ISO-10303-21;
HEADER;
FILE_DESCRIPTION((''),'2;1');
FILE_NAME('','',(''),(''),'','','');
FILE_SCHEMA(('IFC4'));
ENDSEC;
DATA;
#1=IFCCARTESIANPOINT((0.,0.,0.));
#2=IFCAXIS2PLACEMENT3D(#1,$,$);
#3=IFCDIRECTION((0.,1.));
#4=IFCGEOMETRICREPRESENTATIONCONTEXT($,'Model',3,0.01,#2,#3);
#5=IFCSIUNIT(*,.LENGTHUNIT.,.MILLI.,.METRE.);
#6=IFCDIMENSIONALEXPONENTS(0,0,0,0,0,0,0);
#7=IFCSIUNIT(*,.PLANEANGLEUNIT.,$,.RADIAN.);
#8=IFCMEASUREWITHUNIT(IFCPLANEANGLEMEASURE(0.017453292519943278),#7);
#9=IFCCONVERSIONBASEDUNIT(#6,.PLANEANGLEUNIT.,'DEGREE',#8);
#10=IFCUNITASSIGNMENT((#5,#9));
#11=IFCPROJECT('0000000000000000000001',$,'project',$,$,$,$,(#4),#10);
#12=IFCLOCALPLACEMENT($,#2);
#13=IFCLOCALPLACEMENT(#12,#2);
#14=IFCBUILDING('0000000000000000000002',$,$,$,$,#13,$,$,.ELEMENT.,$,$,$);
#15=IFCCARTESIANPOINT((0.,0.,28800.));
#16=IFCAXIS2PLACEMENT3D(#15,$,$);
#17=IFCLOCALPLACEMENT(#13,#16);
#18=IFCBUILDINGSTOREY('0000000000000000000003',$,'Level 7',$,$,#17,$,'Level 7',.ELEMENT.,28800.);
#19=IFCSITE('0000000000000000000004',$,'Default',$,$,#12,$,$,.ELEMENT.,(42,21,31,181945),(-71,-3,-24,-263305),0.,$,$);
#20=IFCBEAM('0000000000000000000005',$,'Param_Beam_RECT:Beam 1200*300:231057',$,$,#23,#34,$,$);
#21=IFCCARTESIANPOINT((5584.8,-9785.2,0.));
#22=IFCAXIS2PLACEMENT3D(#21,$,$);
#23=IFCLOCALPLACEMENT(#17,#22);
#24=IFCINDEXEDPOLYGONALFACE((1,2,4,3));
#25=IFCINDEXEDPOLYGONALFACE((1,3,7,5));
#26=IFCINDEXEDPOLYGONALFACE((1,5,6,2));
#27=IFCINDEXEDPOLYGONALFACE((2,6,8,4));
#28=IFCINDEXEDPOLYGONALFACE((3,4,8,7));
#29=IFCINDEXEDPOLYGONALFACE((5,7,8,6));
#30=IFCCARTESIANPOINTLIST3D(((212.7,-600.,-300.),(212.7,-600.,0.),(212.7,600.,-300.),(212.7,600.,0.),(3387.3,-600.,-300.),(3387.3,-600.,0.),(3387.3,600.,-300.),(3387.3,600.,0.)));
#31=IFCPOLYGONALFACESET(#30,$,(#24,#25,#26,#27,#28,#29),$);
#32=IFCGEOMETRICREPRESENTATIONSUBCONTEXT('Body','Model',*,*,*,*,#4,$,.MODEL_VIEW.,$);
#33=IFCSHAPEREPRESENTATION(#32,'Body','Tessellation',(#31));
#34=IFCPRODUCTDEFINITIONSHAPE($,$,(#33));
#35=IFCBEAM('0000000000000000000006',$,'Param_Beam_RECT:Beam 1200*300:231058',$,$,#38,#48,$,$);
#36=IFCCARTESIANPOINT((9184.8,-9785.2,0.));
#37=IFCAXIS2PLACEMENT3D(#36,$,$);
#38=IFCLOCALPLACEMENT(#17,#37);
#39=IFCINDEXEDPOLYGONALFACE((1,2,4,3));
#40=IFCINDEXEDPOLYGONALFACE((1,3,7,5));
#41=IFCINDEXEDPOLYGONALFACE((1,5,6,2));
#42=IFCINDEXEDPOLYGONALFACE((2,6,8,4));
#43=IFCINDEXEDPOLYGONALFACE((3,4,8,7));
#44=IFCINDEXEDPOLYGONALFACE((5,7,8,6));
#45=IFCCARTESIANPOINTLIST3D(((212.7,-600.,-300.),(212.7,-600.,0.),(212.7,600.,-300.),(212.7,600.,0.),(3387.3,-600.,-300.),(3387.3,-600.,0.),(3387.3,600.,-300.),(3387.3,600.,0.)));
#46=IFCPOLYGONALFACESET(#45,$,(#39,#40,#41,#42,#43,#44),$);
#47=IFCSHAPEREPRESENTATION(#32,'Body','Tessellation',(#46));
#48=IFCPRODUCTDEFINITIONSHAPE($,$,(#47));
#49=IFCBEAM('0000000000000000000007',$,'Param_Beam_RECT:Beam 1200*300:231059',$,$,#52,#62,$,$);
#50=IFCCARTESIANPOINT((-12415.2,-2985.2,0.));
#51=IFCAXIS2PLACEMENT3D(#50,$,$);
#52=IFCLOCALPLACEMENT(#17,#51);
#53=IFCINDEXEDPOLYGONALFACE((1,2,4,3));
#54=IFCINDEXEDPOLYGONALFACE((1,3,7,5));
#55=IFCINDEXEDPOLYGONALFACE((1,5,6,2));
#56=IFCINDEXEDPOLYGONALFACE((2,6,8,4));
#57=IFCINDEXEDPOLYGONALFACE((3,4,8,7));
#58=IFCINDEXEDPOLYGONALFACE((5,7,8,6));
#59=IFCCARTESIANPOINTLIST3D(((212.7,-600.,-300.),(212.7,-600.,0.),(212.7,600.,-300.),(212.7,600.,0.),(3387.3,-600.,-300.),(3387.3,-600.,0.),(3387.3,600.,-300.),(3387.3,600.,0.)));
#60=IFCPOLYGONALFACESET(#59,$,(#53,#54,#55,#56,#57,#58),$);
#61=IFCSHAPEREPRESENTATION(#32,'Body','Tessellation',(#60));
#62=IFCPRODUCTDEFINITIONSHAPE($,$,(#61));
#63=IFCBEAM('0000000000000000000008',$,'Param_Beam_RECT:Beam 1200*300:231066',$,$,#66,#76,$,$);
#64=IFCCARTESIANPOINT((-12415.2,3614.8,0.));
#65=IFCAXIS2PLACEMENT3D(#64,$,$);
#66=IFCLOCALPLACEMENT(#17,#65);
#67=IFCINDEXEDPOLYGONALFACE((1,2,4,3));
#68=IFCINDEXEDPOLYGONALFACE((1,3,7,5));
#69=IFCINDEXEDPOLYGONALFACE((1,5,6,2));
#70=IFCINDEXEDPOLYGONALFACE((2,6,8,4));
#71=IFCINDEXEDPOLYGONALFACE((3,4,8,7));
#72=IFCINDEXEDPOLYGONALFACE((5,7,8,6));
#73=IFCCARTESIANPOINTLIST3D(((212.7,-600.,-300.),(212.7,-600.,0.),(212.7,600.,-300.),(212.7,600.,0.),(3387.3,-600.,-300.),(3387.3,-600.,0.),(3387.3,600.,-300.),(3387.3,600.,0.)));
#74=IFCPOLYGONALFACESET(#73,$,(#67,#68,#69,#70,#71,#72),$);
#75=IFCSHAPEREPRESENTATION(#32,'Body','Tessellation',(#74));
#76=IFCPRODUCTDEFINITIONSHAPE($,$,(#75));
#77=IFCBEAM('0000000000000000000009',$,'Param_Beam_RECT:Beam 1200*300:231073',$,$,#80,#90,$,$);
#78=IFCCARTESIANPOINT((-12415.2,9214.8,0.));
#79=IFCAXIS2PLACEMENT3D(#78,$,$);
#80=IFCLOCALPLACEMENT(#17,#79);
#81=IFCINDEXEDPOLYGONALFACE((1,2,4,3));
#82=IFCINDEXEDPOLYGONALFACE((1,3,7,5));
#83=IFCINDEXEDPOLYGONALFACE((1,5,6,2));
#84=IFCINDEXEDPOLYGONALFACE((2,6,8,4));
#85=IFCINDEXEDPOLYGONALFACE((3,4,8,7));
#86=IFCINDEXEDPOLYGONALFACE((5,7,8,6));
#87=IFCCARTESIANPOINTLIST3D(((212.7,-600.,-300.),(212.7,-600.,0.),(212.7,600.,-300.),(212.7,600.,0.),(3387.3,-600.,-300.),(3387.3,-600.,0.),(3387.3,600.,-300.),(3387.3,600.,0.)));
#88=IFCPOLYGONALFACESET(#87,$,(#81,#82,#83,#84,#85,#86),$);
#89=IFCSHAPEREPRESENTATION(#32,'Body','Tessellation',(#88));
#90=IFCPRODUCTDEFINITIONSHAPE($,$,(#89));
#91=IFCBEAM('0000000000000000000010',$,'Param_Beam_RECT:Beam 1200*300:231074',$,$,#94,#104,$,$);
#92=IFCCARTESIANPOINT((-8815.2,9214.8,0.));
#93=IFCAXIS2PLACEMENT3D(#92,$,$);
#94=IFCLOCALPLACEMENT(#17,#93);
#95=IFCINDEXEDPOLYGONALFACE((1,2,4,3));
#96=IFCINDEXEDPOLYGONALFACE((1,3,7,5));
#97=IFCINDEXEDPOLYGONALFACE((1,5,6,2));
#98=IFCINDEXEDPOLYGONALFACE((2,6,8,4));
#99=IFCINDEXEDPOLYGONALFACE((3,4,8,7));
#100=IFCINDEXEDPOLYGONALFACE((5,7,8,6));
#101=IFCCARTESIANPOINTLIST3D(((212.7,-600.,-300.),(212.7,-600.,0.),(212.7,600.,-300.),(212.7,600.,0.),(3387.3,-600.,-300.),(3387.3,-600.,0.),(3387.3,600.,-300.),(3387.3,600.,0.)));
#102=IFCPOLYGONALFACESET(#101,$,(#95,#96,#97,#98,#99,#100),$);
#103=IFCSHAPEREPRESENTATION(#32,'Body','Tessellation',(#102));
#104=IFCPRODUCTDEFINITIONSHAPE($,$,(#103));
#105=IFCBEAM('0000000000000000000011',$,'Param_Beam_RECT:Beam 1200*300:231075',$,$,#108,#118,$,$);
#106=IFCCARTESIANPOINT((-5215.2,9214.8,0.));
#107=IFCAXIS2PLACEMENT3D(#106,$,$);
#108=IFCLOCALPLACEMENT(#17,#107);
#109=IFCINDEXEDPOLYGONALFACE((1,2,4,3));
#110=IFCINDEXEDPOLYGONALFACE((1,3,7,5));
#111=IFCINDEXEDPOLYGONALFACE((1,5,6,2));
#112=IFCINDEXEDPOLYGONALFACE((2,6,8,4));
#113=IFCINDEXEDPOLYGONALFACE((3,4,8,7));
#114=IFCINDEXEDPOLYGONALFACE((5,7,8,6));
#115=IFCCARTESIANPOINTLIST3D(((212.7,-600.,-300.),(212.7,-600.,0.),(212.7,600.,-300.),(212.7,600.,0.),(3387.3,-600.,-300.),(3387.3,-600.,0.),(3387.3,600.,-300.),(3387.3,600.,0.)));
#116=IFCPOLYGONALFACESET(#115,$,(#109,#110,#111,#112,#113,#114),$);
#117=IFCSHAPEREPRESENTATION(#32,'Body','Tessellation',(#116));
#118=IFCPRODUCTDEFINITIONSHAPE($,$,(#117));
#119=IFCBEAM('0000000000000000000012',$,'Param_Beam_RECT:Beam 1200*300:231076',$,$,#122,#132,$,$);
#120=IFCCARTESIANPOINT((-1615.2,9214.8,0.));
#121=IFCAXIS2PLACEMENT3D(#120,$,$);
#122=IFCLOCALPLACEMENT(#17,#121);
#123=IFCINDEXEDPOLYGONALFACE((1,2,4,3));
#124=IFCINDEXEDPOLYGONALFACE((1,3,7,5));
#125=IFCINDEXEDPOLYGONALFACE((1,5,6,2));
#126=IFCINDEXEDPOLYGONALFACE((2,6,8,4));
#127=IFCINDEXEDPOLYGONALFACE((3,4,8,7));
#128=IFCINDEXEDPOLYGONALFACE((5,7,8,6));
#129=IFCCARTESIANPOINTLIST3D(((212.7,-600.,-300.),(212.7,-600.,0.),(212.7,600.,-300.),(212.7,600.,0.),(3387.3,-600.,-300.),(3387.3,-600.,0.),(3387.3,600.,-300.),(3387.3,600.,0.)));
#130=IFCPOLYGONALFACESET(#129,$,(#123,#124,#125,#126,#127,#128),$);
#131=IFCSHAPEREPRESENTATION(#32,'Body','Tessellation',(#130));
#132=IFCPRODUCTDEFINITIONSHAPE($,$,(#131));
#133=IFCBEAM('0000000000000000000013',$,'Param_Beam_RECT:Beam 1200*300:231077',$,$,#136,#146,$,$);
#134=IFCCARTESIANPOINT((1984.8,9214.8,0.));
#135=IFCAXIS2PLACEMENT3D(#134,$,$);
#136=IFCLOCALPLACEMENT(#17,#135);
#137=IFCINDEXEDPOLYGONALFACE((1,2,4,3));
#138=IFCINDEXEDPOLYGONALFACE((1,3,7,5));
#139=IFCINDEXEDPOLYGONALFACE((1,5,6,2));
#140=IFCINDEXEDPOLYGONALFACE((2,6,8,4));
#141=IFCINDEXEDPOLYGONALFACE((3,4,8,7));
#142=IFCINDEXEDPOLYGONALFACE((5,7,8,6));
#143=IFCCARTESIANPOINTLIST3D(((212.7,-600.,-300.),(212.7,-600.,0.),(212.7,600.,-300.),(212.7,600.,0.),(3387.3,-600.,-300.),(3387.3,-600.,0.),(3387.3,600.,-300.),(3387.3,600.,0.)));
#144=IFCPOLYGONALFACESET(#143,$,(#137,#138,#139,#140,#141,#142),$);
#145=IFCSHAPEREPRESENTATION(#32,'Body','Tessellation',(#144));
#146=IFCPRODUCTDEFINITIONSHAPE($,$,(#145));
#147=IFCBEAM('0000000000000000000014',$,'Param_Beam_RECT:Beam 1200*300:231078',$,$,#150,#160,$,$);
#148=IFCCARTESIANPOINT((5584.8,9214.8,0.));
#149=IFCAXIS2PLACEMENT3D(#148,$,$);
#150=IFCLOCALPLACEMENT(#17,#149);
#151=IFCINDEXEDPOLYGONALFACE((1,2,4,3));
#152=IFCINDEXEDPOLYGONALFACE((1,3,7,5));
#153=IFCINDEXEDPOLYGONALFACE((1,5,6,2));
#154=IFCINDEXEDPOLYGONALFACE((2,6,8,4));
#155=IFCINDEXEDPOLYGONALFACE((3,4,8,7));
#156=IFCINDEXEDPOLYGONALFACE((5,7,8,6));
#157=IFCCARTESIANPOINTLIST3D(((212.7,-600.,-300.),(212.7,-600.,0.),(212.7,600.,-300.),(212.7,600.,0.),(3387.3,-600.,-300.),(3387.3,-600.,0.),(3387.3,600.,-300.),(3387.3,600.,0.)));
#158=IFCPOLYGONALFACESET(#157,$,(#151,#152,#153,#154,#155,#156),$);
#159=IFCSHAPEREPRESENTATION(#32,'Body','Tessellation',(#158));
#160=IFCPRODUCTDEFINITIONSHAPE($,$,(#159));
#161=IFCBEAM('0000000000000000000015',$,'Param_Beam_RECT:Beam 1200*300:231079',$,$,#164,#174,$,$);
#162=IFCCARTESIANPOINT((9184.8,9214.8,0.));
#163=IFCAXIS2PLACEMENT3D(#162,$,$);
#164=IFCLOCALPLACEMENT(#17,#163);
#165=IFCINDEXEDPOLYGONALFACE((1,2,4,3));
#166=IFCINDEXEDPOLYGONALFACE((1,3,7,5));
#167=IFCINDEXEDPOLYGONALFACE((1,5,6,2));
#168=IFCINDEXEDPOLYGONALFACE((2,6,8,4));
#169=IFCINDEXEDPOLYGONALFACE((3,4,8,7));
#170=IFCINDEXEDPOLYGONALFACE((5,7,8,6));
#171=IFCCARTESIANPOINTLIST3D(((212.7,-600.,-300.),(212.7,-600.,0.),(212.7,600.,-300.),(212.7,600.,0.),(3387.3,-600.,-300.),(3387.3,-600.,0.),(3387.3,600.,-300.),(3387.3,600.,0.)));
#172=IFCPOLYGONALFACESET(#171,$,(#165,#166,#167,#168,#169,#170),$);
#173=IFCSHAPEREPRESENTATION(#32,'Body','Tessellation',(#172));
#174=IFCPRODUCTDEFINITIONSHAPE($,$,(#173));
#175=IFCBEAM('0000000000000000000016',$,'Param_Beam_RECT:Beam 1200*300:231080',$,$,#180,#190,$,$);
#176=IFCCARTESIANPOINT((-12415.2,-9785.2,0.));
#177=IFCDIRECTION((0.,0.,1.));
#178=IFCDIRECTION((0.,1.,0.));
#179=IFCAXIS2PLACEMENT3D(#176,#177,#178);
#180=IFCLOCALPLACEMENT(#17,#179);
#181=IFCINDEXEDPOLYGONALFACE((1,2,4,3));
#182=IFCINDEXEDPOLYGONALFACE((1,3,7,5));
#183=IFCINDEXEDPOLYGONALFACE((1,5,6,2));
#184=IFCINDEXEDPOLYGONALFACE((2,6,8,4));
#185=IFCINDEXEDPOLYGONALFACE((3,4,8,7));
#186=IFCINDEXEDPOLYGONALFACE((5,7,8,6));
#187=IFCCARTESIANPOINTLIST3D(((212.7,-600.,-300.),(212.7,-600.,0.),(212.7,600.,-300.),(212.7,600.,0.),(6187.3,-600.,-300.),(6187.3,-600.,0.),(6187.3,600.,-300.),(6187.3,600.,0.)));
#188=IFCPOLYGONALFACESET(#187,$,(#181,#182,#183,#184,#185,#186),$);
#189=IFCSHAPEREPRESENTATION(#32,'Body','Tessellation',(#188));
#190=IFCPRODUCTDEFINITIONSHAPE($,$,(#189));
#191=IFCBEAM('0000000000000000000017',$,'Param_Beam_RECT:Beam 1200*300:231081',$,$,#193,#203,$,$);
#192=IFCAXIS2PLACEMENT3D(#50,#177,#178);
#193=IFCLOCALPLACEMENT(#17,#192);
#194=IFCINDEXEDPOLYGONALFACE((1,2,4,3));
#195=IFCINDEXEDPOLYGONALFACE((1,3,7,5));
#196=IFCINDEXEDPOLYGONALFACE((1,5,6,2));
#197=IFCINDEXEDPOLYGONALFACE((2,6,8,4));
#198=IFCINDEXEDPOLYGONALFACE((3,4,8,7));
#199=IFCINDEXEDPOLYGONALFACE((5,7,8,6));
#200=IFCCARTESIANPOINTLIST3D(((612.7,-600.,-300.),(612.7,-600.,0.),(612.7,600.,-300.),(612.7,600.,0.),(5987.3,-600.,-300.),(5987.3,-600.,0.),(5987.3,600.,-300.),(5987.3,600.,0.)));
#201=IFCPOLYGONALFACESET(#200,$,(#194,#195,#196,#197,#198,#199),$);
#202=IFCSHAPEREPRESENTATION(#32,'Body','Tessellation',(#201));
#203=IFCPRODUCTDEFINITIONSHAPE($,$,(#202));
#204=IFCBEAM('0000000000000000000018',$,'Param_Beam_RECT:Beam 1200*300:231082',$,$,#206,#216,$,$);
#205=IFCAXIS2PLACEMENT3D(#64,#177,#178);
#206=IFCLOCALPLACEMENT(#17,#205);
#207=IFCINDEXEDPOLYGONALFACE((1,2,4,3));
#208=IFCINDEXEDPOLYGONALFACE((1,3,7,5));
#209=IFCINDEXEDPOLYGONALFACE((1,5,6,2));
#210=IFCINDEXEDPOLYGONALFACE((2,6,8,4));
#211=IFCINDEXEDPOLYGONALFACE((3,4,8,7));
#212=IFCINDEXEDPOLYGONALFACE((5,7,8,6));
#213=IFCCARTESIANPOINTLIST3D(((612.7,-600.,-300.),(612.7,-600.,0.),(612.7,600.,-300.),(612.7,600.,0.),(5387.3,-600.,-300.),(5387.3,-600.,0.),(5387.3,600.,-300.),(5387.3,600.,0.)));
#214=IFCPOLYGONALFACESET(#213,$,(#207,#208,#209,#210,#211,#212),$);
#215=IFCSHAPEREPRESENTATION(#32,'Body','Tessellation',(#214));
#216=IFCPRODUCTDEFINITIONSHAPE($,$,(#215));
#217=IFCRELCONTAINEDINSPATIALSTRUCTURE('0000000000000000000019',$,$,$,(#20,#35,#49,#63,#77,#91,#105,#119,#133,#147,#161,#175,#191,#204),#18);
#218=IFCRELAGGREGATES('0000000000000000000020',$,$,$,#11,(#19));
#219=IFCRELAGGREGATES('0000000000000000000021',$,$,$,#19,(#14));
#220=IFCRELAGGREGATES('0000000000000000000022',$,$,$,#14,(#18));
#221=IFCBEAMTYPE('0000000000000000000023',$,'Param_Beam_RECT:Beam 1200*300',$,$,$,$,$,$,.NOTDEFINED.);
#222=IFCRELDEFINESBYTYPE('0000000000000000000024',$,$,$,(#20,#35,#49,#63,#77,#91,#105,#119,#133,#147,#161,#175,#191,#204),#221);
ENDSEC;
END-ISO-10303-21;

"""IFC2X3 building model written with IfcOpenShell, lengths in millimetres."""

from ifc_helpers import new_model, entity, si_unit, converted_unit, direction, frame, frame_2d, origin, origin_2d_with_axis, place, context, subcontext, project, spatial, rectangle, extrude, type_object, element, save


model = new_model("IFC2X3")

# Units and contexts
model_context = context("Model", 3, precision=0.01, world=origin(), true_north=direction((0.0, 1.0)))
body_context = subcontext(model_context, "Body", "Model", "MODEL_VIEW")
ifc_project = project(units=[si_unit("LENGTHUNIT", "METRE", prefix="MILLI"), converted_unit("PLANEANGLEUNIT", "DEGREE", entity("IfcPlaneAngleMeasure", 0.017453292519943278), si_unit("PLANEANGLEUNIT", "RADIAN"), dimensions=[0, 0, 0, 0, 0, 0, 0])], contexts=[model_context])

# Site, building, storey
site_placement = place(None, origin())
site = spatial("IfcSite", under=ifc_project, at=site_placement, Name="Default", CompositionType="ELEMENT", RefLatitude=(42, 21, 31, 181945), RefLongitude=(-71, -3, -24, -263305), RefElevation=0.0)
building_placement = place(site_placement, origin())
building = spatial("IfcBuilding", under=site, at=building_placement, CompositionType="ELEMENT")
storey_placement = place(building_placement, frame((0.0, 0.0, 28800.0)))
storey = spatial("IfcBuildingStorey", under=building, at=storey_placement, Name="Level 7", LongName="Level 7", CompositionType="ELEMENT", Elevation=28800.0)

# Beams
beam_type_1 = type_object("IfcBeamType", Name="Param_Beam_RECT:Beam 1200*300", PredefinedType="NOTDEFINED")
for number, where, name in (
    (1, (5584.8, -9785.2, 0.0), "Param_Beam_RECT:Beam 1200*300:231057"),
    (2, (9184.8, -9785.2, 0.0), "Param_Beam_RECT:Beam 1200*300:231058"),
):
    element("IfcBeam", number, at=place(storey_placement, frame(where)), inside=storey, type_object=beam_type_1, Name=name, context=body_context, shape_type="SweptSolid", body=[
        extrude(rectangle(XDim=300.0, YDim=1200.0, at=frame_2d((0.0, 0.0), x_axis=(1.0, 0.0))), frame((212.7, 0.0, -150.0), z_axis=(1.0, 0.0, 0.0), x_axis=(0.0, 0.0, -1.0)), (0.0, 0.0, 1.0), 3174.6),
    ])
beam_1_placement = place(storey_placement, frame((-12415.2, -2985.2, 0.0)))
element("IfcBeam", 3, at=beam_1_placement, inside=storey, type_object=beam_type_1, Name="Param_Beam_RECT:Beam 1200*300:231059", context=body_context, shape_type="SweptSolid", body=[
    extrude(rectangle(XDim=300.0, YDim=1200.0, at=frame_2d((0.0, 0.0), x_axis=(1.0, 0.0))), frame((212.7, 0.0, -150.0), z_axis=(1.0, 0.0, 0.0), x_axis=(0.0, 0.0, -1.0)), (0.0, 0.0, 1.0), 3174.6),
])
beam_2_placement = place(storey_placement, frame((-12415.2, 3614.8, 0.0)))
element("IfcBeam", 4, at=beam_2_placement, inside=storey, type_object=beam_type_1, Name="Param_Beam_RECT:Beam 1200*300:231066", context=body_context, shape_type="SweptSolid", body=[
    extrude(rectangle(XDim=300.0, YDim=1200.0, at=origin_2d_with_axis()), frame((212.7, 0.0, -150.0), z_axis=(1.0, 0.0, 0.0), x_axis=(0.0, 0.0, -1.0)), (0.0, 0.0, 1.0), 3174.6),
])
beam_3_placement = place(storey_placement, frame((-12415.2, 9214.8, 0.0)))
element("IfcBeam", 5, at=beam_3_placement, inside=storey, type_object=beam_type_1, Name="Param_Beam_RECT:Beam 1200*300:231073", context=body_context, shape_type="SweptSolid", body=[
    extrude(rectangle(XDim=300.0, YDim=1200.0, at=frame_2d((0.0, 0.0), x_axis=(1.0, 0.0))), frame((212.7, 0.0, -150.0), z_axis=(1.0, 0.0, 0.0), x_axis=(0.0, 0.0, -1.0)), (0.0, 0.0, 1.0), 3174.6),
])
for number, where, name in (
    (6, (-8815.2, 9214.8, 0.0), "Param_Beam_RECT:Beam 1200*300:231074"),
    (7, (-5215.2, 9214.8, 0.0), "Param_Beam_RECT:Beam 1200*300:231075"),
):
    element("IfcBeam", number, at=place(storey_placement, frame(where)), inside=storey, type_object=beam_type_1, Name=name, context=body_context, shape_type="SweptSolid", body=[
        extrude(rectangle(XDim=300.0, YDim=1200.0, at=frame_2d((0.0, 0.0), x_axis=(1.0, 0.0))), frame((212.7, 0.0, -150.0), z_axis=(1.0, 0.0, 0.0), x_axis=(0.0, 0.0, -1.0)), (0.0, 0.0, 1.0), 3174.6),
    ])
beam_4_placement = place(storey_placement, frame((-1615.2, 9214.8, 0.0)))
element("IfcBeam", 8, at=beam_4_placement, inside=storey, type_object=beam_type_1, Name="Param_Beam_RECT:Beam 1200*300:231076", context=body_context, shape_type="SweptSolid", body=[
    extrude(rectangle(XDim=300.0, YDim=1200.0, at=frame_2d((0.0, 0.0), x_axis=(1.0, 0.0))), frame((212.7, 0.0, -150.0), z_axis=(1.0, 0.0, 0.0), x_axis=(0.0, 0.0, -1.0)), (0.0, 0.0, 1.0), 3174.6),
])
beam_5_placement = place(storey_placement, frame((1984.8, 9214.8, 0.0)))
element("IfcBeam", 9, at=beam_5_placement, inside=storey, type_object=beam_type_1, Name="Param_Beam_RECT:Beam 1200*300:231077", context=body_context, shape_type="SweptSolid", body=[
    extrude(rectangle(XDim=300.0, YDim=1200.0, at=origin_2d_with_axis()), frame((212.7, 0.0, -150.0), z_axis=(1.0, 0.0, 0.0), x_axis=(0.0, 0.0, -1.0)), (0.0, 0.0, 1.0), 3174.6),
])
for number, where, name in (
    (10, (5584.8, 9214.8, 0.0), "Param_Beam_RECT:Beam 1200*300:231078"),
    (11, (9184.8, 9214.8, 0.0), "Param_Beam_RECT:Beam 1200*300:231079"),
):
    element("IfcBeam", number, at=place(storey_placement, frame(where)), inside=storey, type_object=beam_type_1, Name=name, context=body_context, shape_type="SweptSolid", body=[
        extrude(rectangle(XDim=300.0, YDim=1200.0, at=frame_2d((0.0, 0.0), x_axis=(1.0, 0.0))), frame((212.7, 0.0, -150.0), z_axis=(1.0, 0.0, 0.0), x_axis=(0.0, 0.0, -1.0)), (0.0, 0.0, 1.0), 3174.6),
    ])
beam_6_placement = place(storey_placement, frame((-12415.2, -9785.2, 0.0), z_axis=(0.0, 0.0, 1.0), x_axis=(0.0, 1.0, 0.0)))
element("IfcBeam", 12, at=beam_6_placement, inside=storey, type_object=beam_type_1, Name="Param_Beam_RECT:Beam 1200*300:231080", context=body_context, shape_type="SweptSolid", body=[
    extrude(rectangle(XDim=300.0, YDim=1200.0, at=origin_2d_with_axis()), frame((212.7, 0.0, -150.0), z_axis=(1.0, 0.0, 0.0), x_axis=(0.0, 0.0, -1.0)), (0.0, 0.0, 1.0), 5974.6),
])
beam_7_placement = place(storey_placement, frame((-12415.2, -2985.2, 0.0), z_axis=(0.0, 0.0, 1.0), x_axis=(0.0, 1.0, 0.0)))
element("IfcBeam", 13, at=beam_7_placement, inside=storey, type_object=beam_type_1, Name="Param_Beam_RECT:Beam 1200*300:231081", context=body_context, shape_type="SweptSolid", body=[
    extrude(rectangle(XDim=300.0, YDim=1200.0, at=frame_2d((0.0, 0.0), x_axis=(1.0, 0.0))), frame((612.7, 0.0, -150.0), z_axis=(1.0, 0.0, 0.0), x_axis=(0.0, 0.0, -1.0)), (0.0, 0.0, 1.0), 5374.6),
])
beam_8_placement = place(storey_placement, frame((-12415.2, 3614.8, 0.0), z_axis=(0.0, 0.0, 1.0), x_axis=(0.0, 1.0, 0.0)))
element("IfcBeam", 14, at=beam_8_placement, inside=storey, type_object=beam_type_1, Name="Param_Beam_RECT:Beam 1200*300:231082", context=body_context, shape_type="SweptSolid", body=[
    extrude(rectangle(XDim=300.0, YDim=1200.0, at=origin_2d_with_axis()), frame((612.7, 0.0, -150.0), z_axis=(1.0, 0.0, 0.0), x_axis=(0.0, 0.0, -1.0)), (0.0, 0.0, 1.0), 4774.6),
])

save(model, "model.ifc")
